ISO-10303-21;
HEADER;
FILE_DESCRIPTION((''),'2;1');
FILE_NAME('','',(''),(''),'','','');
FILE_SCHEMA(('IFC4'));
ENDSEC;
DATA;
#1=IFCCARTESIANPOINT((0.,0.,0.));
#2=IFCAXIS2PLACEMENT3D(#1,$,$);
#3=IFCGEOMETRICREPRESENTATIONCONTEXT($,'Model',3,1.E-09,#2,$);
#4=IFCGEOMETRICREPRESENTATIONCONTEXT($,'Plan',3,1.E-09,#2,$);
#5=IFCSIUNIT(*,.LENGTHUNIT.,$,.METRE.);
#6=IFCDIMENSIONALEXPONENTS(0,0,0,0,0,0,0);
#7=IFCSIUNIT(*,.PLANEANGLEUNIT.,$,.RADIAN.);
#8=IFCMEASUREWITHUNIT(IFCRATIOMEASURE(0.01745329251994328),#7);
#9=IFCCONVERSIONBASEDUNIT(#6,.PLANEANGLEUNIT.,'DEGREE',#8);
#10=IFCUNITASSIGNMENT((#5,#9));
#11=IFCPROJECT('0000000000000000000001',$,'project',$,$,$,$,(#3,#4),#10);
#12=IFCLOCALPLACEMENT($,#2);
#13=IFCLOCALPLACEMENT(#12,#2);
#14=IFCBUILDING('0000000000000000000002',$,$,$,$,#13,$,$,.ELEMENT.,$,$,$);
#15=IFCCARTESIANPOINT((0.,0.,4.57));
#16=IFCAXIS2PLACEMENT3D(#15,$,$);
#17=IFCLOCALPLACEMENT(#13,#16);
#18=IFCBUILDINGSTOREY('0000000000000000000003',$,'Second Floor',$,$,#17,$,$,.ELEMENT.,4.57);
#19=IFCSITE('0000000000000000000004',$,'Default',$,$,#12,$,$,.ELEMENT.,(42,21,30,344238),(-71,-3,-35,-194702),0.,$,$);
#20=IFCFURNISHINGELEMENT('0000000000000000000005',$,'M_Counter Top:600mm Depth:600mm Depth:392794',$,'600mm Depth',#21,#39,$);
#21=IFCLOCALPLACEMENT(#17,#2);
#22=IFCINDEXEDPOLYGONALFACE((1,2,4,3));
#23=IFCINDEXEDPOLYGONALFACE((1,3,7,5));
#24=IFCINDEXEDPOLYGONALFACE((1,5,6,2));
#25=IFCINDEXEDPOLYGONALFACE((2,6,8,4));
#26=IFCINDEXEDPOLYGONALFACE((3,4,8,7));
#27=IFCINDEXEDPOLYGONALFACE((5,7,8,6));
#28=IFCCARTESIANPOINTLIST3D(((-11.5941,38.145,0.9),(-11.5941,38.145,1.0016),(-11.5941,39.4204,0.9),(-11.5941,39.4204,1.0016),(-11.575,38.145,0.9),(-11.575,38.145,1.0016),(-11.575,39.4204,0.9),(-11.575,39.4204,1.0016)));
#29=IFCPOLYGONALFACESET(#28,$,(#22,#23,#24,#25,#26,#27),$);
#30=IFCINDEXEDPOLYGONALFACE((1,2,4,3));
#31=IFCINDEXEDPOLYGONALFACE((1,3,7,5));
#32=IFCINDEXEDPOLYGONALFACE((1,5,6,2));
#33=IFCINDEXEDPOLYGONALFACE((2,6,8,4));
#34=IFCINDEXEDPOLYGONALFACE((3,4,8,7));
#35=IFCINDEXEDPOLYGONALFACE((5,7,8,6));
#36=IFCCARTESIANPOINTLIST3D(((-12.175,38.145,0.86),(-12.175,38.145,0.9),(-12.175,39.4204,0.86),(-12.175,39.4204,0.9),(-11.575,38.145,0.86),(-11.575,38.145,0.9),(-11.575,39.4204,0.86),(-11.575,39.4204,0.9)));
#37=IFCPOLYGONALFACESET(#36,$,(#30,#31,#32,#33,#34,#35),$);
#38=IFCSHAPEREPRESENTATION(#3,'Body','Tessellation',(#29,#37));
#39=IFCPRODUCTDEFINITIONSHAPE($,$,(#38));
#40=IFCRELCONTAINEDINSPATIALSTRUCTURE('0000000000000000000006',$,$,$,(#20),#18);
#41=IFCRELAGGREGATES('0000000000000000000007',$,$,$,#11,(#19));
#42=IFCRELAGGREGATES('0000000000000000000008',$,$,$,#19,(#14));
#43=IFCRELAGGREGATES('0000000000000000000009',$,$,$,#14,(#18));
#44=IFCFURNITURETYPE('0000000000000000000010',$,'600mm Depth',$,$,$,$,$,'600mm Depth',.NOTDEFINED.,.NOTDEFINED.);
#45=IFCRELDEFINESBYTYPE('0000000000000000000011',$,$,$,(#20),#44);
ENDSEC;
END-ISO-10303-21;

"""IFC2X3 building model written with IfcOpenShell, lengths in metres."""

from ifc_helpers import new_model, entity, si_unit, converted_unit, frame, origin, origin_2d_with_axis, place, context, project, spatial, rectangle, extrude, source, transform, mapped, type_object, type_shapes, element, save


model = new_model("IFC2X3")

# Units and contexts
model_context = context("Model", 3, precision=1e-09, world=origin())
plan_context = context("Plan", 3, precision=1e-09, world=origin())
ifc_project = project(units=[si_unit("LENGTHUNIT", "METRE"), converted_unit("PLANEANGLEUNIT", "DEGREE", entity("IfcRatioMeasure", 0.01745329251994328), si_unit("PLANEANGLEUNIT", "RADIAN"), dimensions=[0, 0, 0, 0, 0, 0, 0])], contexts=[model_context, plan_context])

# Site, building, storey
site_placement = place(None, origin())
site = spatial("IfcSite", under=ifc_project, at=site_placement, Name="Default", CompositionType="ELEMENT", RefLatitude=(42, 21, 30, 344238), RefLongitude=(-71, -3, -35, -194702), RefElevation=0.0)
building_placement = place(site_placement, origin())
building = spatial("IfcBuilding", under=site, at=building_placement, CompositionType="ELEMENT")
storey_placement = place(building_placement, frame((0.0, 0.0, 4.57)))
storey = spatial("IfcBuildingStorey", under=building, at=storey_placement, Name="Second Floor", CompositionType="ELEMENT", Elevation=4.57)

# Furnishing element
furniture_type = type_object("IfcFurnitureType", Name="600mm Depth", ElementType="600mm Depth", AssemblyPlace="NOTDEFINED")
shared_shape_1 = source(origin(), model_context, "Body", "SweptSolid", [
    extrude(rectangle(XDim=0.0191, YDim=1.2755, at=origin_2d_with_axis()), frame((-0.5627, -0.0095, 0.9), z_axis=(0.0, 0.0, 1.0), x_axis=(0.0, -1.0, 0.0)), (0.0, 0.0, 1.0), 0.1016),
    extrude(rectangle(XDim=1.2755, YDim=0.6, at=origin_2d_with_axis()), frame((-0.5627, -0.3, 0.86), z_axis=(0.0, 0.0, 1.0), x_axis=(-1.0, 0.0, 0.0)), (0.0, 0.0, 1.0), 0.04),
])
type_shapes(furniture_type, [shared_shape_1])
furnishing_placement = place(storey_placement, frame((-11.575, 38.22, 0.0), z_axis=(0.0, 0.0, 1.0), x_axis=(0.0, -1.0, 0.0)))
element("IfcFurnishingElement", 1, at=furnishing_placement, inside=storey, type_object=furniture_type, Name="M_Counter Top:600mm Depth:600mm Depth:392794", ObjectType="600mm Depth", context=model_context, shape_type="MappedRepresentation", body=[
    mapped(shared_shape_1, transform((0.0, 0.0, 0.0), scale=1.0)),
])

save(model, "model.ifc")
